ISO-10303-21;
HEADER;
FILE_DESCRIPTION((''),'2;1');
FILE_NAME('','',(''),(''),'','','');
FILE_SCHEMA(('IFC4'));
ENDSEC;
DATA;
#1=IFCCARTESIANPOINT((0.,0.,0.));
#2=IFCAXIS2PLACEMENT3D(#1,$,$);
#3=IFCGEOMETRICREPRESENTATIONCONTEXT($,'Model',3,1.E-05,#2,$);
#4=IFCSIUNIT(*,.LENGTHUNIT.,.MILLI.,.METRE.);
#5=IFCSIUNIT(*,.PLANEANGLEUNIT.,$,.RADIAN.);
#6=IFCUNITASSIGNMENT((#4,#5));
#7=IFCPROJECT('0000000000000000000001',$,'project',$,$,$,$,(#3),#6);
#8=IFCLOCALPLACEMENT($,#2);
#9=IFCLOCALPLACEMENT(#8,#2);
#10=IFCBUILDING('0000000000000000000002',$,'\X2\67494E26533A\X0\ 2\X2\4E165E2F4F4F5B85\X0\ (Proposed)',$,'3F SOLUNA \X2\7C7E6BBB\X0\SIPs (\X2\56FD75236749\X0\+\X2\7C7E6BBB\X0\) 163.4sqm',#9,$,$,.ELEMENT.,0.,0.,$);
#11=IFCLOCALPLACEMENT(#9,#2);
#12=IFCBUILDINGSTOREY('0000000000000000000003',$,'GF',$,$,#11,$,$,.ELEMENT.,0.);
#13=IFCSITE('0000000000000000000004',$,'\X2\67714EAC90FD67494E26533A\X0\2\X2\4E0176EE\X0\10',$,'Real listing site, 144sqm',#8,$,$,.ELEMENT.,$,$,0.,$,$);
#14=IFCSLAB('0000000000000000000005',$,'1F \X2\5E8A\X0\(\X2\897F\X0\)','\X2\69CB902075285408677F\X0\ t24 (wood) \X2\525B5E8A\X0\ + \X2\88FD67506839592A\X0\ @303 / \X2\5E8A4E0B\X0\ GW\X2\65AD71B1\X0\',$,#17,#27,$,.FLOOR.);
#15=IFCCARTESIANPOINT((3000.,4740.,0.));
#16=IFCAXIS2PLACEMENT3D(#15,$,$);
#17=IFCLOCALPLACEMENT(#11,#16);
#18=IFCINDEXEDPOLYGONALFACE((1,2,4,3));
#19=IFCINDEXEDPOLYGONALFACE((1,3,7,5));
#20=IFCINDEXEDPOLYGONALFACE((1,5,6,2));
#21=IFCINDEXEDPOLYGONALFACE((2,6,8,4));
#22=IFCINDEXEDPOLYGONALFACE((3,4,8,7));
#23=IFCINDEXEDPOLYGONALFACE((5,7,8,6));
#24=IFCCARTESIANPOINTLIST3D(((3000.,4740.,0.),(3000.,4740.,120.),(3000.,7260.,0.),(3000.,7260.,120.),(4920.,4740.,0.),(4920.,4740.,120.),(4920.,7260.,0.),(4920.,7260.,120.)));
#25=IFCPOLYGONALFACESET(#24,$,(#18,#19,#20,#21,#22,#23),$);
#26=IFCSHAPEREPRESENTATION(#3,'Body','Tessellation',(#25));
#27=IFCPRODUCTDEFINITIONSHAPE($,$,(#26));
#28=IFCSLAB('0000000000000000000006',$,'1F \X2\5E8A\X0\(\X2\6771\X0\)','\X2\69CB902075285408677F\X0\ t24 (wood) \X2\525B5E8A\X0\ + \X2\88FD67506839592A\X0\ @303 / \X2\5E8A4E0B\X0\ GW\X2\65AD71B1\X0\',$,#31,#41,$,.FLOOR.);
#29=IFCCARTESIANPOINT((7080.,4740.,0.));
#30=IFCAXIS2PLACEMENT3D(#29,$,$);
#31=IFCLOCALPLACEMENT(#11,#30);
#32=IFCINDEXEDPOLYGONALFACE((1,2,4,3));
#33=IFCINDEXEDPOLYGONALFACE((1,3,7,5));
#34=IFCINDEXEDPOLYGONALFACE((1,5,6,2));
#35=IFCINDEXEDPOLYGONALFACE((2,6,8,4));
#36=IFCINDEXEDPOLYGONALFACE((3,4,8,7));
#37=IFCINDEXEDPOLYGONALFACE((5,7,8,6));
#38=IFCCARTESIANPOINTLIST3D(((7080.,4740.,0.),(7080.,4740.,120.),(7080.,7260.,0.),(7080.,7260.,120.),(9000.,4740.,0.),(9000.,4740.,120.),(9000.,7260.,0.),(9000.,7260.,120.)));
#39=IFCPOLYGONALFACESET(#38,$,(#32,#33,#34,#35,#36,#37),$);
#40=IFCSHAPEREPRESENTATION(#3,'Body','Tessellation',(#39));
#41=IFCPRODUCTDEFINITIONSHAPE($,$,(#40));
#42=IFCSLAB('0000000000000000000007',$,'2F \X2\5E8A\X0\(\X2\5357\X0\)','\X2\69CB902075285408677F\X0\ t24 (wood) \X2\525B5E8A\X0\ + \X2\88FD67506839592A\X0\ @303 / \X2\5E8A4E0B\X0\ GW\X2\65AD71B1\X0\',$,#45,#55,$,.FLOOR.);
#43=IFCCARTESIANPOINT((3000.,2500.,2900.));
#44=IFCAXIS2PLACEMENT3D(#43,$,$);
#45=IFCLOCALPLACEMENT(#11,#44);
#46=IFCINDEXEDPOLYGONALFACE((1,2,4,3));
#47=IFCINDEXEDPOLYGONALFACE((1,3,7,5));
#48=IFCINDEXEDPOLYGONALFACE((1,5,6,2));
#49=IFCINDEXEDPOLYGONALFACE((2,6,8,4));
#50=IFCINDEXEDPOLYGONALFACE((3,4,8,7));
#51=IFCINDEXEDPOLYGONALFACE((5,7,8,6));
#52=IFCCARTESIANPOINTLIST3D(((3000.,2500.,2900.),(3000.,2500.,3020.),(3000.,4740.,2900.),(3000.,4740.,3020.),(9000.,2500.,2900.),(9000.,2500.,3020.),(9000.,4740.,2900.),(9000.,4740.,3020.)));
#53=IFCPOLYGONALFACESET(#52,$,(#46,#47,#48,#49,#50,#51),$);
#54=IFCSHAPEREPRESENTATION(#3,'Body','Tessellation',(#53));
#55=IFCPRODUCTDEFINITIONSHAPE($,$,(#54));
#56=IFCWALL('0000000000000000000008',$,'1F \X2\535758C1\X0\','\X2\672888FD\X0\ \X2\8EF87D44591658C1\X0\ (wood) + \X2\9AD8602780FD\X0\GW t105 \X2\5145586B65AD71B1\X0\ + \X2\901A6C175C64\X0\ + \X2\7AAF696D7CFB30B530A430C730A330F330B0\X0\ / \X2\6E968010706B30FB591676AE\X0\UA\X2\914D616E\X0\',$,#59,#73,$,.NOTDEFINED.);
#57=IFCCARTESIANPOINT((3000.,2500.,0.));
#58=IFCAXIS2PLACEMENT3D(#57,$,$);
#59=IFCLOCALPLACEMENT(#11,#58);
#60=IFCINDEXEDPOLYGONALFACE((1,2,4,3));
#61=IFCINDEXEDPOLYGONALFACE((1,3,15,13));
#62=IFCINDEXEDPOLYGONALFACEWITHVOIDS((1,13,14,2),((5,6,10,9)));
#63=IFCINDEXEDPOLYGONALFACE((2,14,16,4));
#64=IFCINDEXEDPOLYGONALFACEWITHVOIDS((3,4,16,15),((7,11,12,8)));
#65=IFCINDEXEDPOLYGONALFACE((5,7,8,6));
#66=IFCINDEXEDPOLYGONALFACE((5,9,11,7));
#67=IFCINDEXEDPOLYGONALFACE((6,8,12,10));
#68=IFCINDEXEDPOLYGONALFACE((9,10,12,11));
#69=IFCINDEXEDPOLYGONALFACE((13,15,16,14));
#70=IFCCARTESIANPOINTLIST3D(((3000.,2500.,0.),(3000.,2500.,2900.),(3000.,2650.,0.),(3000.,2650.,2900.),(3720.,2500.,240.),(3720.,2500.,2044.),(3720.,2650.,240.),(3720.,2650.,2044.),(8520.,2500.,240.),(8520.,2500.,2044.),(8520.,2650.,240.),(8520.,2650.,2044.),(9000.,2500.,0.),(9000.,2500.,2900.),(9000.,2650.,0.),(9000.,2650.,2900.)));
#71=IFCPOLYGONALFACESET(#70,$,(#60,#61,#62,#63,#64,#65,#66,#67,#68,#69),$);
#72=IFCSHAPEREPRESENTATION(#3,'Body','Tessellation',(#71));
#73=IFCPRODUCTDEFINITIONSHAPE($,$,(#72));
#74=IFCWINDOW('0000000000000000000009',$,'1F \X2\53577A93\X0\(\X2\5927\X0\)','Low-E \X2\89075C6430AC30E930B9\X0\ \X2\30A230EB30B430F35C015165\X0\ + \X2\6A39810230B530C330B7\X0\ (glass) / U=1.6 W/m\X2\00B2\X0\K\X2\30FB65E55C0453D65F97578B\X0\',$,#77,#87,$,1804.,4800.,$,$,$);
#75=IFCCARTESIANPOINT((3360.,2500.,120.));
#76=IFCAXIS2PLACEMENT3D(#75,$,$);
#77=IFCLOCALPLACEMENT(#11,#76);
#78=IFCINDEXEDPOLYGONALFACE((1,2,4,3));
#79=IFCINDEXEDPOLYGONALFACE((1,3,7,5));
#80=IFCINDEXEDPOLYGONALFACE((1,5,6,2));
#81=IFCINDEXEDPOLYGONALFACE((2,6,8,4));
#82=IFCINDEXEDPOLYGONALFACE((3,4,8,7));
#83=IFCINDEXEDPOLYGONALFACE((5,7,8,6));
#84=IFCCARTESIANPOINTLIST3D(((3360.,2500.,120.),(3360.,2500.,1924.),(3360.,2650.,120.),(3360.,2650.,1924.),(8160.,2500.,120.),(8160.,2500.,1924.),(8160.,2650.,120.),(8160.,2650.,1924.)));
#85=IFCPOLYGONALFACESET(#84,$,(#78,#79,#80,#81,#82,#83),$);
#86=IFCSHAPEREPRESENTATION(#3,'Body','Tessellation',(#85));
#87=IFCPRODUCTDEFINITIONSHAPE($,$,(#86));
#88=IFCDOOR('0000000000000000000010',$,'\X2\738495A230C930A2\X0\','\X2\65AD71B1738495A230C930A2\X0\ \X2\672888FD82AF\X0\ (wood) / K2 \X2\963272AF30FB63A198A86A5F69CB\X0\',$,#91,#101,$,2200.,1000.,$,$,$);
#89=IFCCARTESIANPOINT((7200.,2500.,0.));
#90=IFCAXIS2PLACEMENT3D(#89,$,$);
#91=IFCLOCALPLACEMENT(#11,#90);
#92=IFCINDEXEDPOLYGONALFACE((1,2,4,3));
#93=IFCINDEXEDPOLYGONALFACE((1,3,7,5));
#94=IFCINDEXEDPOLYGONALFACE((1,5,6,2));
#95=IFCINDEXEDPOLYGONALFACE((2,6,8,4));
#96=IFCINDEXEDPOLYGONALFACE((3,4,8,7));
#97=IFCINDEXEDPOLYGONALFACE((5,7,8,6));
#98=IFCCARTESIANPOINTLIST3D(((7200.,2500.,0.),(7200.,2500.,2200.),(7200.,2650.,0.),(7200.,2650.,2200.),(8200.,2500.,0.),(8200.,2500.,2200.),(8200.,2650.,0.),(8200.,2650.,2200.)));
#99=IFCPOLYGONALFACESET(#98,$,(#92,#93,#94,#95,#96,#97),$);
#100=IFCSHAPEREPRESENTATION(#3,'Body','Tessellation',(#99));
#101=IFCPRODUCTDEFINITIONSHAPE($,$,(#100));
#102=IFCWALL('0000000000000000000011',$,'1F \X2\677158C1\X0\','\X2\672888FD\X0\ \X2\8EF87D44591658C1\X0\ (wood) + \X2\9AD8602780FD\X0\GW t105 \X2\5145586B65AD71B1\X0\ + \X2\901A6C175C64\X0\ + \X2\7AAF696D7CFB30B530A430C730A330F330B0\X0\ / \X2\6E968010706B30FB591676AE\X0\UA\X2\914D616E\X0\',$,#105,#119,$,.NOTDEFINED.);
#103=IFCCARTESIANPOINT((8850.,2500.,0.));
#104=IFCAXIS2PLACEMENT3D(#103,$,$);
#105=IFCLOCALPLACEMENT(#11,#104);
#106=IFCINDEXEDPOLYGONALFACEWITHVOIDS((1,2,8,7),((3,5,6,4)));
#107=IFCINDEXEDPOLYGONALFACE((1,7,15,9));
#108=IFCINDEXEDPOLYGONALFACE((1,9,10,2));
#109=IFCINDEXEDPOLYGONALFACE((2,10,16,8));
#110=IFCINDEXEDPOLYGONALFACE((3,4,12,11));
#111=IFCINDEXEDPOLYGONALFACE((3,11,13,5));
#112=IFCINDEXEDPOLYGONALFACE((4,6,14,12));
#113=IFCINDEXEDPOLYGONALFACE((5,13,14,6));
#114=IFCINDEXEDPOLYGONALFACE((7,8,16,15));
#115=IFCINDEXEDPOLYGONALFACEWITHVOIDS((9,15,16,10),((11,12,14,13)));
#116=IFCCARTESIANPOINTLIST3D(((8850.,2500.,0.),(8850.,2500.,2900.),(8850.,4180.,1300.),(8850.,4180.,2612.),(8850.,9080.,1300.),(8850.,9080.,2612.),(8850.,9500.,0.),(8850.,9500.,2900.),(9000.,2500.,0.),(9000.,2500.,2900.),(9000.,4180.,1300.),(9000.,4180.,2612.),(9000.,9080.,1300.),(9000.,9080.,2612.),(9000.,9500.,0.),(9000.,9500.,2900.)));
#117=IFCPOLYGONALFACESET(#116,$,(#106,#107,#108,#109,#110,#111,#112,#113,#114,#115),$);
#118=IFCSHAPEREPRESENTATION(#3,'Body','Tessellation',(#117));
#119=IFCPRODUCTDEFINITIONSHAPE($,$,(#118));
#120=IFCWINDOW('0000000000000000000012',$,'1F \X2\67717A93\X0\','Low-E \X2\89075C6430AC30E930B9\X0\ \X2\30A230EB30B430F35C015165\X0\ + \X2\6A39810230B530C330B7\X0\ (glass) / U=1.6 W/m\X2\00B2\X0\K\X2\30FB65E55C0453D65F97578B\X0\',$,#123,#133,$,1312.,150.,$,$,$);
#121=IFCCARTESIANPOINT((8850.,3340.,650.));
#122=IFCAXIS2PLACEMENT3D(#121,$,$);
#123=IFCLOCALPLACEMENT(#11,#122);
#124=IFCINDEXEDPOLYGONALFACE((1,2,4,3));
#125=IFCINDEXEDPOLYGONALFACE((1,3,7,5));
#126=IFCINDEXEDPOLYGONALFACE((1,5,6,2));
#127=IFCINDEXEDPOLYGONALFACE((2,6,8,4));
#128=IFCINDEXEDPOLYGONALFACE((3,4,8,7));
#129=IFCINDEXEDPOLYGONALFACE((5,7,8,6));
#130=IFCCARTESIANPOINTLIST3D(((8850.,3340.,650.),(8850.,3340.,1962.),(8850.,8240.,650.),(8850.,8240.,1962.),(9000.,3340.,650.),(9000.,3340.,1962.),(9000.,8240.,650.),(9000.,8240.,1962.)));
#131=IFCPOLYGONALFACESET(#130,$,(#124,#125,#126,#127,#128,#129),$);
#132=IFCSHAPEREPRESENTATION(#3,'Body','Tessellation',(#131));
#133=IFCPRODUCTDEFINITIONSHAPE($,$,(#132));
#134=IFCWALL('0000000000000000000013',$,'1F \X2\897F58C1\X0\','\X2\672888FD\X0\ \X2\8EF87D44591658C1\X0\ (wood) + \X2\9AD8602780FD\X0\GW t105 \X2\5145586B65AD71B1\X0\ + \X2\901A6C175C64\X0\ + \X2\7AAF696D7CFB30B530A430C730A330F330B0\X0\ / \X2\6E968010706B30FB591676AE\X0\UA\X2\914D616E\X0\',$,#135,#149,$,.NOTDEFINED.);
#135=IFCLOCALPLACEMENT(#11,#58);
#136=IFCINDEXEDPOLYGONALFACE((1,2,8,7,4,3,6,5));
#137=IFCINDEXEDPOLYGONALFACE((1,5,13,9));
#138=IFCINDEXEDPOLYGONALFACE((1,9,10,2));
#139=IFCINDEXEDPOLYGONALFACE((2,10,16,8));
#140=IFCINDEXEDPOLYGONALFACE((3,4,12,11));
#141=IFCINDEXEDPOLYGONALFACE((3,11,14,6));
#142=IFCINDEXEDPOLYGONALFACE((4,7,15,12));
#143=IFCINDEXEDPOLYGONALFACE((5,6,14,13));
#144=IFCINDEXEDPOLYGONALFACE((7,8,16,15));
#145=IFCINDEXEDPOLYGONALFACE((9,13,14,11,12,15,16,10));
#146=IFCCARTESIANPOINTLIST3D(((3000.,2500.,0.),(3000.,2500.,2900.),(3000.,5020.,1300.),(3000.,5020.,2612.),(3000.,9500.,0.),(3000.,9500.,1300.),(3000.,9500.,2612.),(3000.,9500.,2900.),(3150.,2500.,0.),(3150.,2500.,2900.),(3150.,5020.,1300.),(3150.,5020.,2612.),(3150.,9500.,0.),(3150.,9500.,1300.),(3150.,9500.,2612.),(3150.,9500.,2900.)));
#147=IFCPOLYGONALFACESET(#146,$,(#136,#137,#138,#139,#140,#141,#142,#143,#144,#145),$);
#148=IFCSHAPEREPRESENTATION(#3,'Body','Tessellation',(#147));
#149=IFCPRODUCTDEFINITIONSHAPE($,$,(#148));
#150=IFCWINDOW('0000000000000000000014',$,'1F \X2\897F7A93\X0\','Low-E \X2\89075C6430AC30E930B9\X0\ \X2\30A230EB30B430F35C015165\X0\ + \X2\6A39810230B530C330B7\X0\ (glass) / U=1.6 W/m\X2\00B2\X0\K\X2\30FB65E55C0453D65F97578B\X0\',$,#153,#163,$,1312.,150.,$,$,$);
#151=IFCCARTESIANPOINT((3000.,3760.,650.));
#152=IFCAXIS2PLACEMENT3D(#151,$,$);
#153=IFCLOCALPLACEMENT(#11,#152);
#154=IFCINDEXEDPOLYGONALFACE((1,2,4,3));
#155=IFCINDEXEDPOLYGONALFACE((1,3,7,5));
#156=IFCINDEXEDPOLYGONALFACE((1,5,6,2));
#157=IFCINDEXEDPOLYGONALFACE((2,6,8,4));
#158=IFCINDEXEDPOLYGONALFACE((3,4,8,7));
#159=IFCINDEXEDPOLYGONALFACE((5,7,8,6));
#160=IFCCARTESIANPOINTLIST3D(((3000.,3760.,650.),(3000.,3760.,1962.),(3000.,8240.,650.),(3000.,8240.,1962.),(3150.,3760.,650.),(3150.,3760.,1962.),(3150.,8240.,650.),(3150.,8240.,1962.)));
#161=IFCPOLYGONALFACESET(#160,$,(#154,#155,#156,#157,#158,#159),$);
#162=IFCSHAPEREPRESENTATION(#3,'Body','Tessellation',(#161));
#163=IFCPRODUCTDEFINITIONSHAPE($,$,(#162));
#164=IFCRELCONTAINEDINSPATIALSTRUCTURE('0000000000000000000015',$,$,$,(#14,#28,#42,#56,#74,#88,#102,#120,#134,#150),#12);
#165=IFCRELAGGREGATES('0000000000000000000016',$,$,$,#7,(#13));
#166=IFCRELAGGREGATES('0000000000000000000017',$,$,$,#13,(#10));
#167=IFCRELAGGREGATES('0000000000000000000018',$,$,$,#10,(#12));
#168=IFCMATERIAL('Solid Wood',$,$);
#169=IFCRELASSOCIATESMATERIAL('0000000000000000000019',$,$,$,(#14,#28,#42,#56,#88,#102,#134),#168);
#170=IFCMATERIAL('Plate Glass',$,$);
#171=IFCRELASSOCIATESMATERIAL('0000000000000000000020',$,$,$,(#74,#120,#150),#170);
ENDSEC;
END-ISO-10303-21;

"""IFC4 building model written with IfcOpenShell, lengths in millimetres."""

from ifc_helpers import new_model, si_unit, frame, frame_2d, origin, place, context, project, spatial, rectangle, extrude, material, element, fill, save


model = new_model("IFC4")

# Units and contexts
model_context = context("Model", 3, precision=1e-05, world=origin())
ifc_project = project(units=[si_unit("LENGTHUNIT", "METRE", prefix="MILLI"), si_unit("PLANEANGLEUNIT", "RADIAN")], contexts=[model_context])

# Site, building, storey
site_placement = place(None, origin())
site = spatial("IfcSite", under=ifc_project, at=site_placement, Name="東京都杉並区2丁目10", ObjectType="Real listing site, 144sqm", CompositionType="ELEMENT", RefElevation=0.0)
building_placement = place(site_placement, origin())
building = spatial("IfcBuilding", under=site, at=building_placement, Name="杉並区 2世帯住宅 (Proposed)", ObjectType="3F SOLUNA 籾殻SIPs (国産杉+籾殻) 163.4sqm", CompositionType="ELEMENT", ElevationOfRefHeight=0.0, ElevationOfTerrain=0.0)
storey_placement = place(building_placement, origin())
storey = spatial("IfcBuildingStorey", under=building, at=storey_placement, Name="GF", CompositionType="ELEMENT", Elevation=0.0)

# Slabs
ifc_material_1 = material(Name="Solid Wood")
slab_1_placement = place(storey_placement, frame((3000.0, 4740.0, 0.0)))
element("IfcSlab", 1, at=slab_1_placement, inside=storey, material=ifc_material_1, Name="1F 床(西)", Description="構造用合板 t24 (wood) 剛床 + 製材根太 @303 / 床下 GW断熱", PredefinedType="FLOOR", context=model_context, shape_type="SweptSolid", body=[
    extrude(rectangle(XDim=1920.0, YDim=2520.0, at=frame_2d((960.0, 1260.0))), frame((3000.0, 4740.0, 0.0)), (0.0, 0.0, 1.0), 120.0),
])
slab_2_placement = place(storey_placement, frame((7080.0, 4740.0, 0.0)))
element("IfcSlab", 2, at=slab_2_placement, inside=storey, material=ifc_material_1, Name="1F 床(東)", Description="構造用合板 t24 (wood) 剛床 + 製材根太 @303 / 床下 GW断熱", PredefinedType="FLOOR", context=model_context, shape_type="SweptSolid", body=[
    extrude(rectangle(XDim=1920.0, YDim=2520.0, at=frame_2d((960.0, 1260.0))), frame((7080.0, 4740.0, 0.0)), (0.0, 0.0, 1.0), 120.0),
])
slab_3_placement = place(storey_placement, frame((3000.0, 2500.0, 2900.0)))
element("IfcSlab", 3, at=slab_3_placement, inside=storey, material=ifc_material_1, Name="2F 床(南)", Description="構造用合板 t24 (wood) 剛床 + 製材根太 @303 / 床下 GW断熱", PredefinedType="FLOOR", context=model_context, shape_type="SweptSolid", body=[
    extrude(rectangle(XDim=6000.0, YDim=2240.0, at=frame_2d((3000.0, 1120.0))), frame((3000.0, 2500.0, 2900.0)), (0.0, 0.0, 1.0), 120.0),
])

# Wall, openings, window, door
wall_1_placement = place(storey_placement, frame((3000.0, 2500.0, 0.0)))
wall_1 = element("IfcWall", 4, at=wall_1_placement, inside=storey, material=ifc_material_1, Name="1F 南壁", Description="木製 軸組外壁 (wood) + 高性能GW t105 充填断熱 + 通気層 + 窯業系サイディング / 準耐火・外皮UA配慮", PredefinedType="NOTDEFINED", context=model_context, shape_type="SweptSolid", body=[
    extrude(rectangle(XDim=6000.0, YDim=150.0, at=frame_2d((3000.0, 75.0))), frame((3000.0, 2500.0, 0.0)), (0.0, 0.0, 1.0), 2900.0),
])
opening_1_placement = place(storey_placement, frame((3360.0, 2500.0, 120.0)))
opening_1 = element("IfcOpeningElement", 5, at=opening_1_placement, cuts=wall_1, PredefinedType="NOTDEFINED", context=model_context, shape_type="SweptSolid", body=[
    extrude(rectangle(XDim=4800.0, YDim=150.0, at=frame_2d((2400.0, 75.0))), frame((3360.0, 2500.0, 120.0)), (0.0, 0.0, 1.0), 1804.0),
])
opening_2_placement = place(storey_placement, frame((7200.0, 2500.0, 0.0)))
opening_2 = element("IfcOpeningElement", 6, at=opening_2_placement, cuts=wall_1, PredefinedType="NOTDEFINED", context=model_context, shape_type="SweptSolid", body=[
    extrude(rectangle(XDim=1000.0, YDim=150.0, at=frame_2d((500.0, 75.0))), frame((7200.0, 2500.0, 0.0)), (0.0, 0.0, 1.0), 2200.0),
])
ifc_material_2 = material(Name="Plate Glass")
window_1_placement = place(storey_placement, frame((3360.0, 2500.0, 120.0)))
window_1 = element("IfcWindow", 7, at=window_1_placement, inside=storey, material=ifc_material_2, Name="1F 南窓(大)", Description="Low-E 複層ガラス アルゴン封入 + 樹脂サッシ (glass) / U=1.6 W/m²K・日射取得型", OverallHeight=1804.0, OverallWidth=4800.0, context=model_context, shape_type="SweptSolid", body=[
    extrude(rectangle(XDim=4800.0, YDim=150.0, at=frame_2d((2400.0, 75.0))), frame((3360.0, 2500.0, 120.0)), (0.0, 0.0, 1.0), 1804.0),
])
fill(opening_1, window_1)
door_placement = place(storey_placement, frame((7200.0, 2500.0, 0.0)))
door = element("IfcDoor", 8, at=door_placement, inside=storey, material=ifc_material_1, Name="玄関ドア", Description="断熱玄関ドア 木製芯 (wood) / K2 防犯・採風機構", OverallHeight=2200.0, OverallWidth=1000.0, context=model_context, shape_type="SweptSolid", body=[
    extrude(rectangle(XDim=1000.0, YDim=150.0, at=frame_2d((500.0, 75.0))), frame((7200.0, 2500.0, 0.0)), (0.0, 0.0, 1.0), 2200.0),
])
fill(opening_2, door)

# Walls, openings, windows
wall_2_placement = place(storey_placement, frame((8850.0, 2500.0, 0.0)))
wall_2 = element("IfcWall", 9, at=wall_2_placement, inside=storey, material=ifc_material_1, Name="1F 東壁", Description="木製 軸組外壁 (wood) + 高性能GW t105 充填断熱 + 通気層 + 窯業系サイディング / 準耐火・外皮UA配慮", PredefinedType="NOTDEFINED", context=model_context, shape_type="SweptSolid", body=[
    extrude(rectangle(XDim=150.0, YDim=7000.0, at=frame_2d((75.0, 3500.0))), frame((8850.0, 2500.0, 0.0)), (0.0, 0.0, 1.0), 2900.0),
])
opening_3_placement = place(storey_placement, frame((8850.0, 3340.0, 650.0)))
opening_3 = element("IfcOpeningElement", 10, at=opening_3_placement, cuts=wall_2, PredefinedType="NOTDEFINED", context=model_context, shape_type="SweptSolid", body=[
    extrude(rectangle(XDim=150.0, YDim=4900.0, at=frame_2d((75.0, 2450.0))), frame((8850.0, 3340.0, 650.0)), (0.0, 0.0, 1.0), 1312.0),
])
window_2_placement = place(storey_placement, frame((8850.0, 3340.0, 650.0)))
window_2 = element("IfcWindow", 11, at=window_2_placement, inside=storey, material=ifc_material_2, Name="1F 東窓", Description="Low-E 複層ガラス アルゴン封入 + 樹脂サッシ (glass) / U=1.6 W/m²K・日射取得型", OverallHeight=1312.0, OverallWidth=150.0, context=model_context, shape_type="SweptSolid", body=[
    extrude(rectangle(XDim=150.0, YDim=4900.0, at=frame_2d((75.0, 2450.0))), frame((8850.0, 3340.0, 650.0)), (0.0, 0.0, 1.0), 1312.0),
])
fill(opening_3, window_2)
wall_3_placement = place(storey_placement, frame((3000.0, 2500.0, 0.0)))
wall_3 = element("IfcWall", 12, at=wall_3_placement, inside=storey, material=ifc_material_1, Name="1F 西壁", Description="木製 軸組外壁 (wood) + 高性能GW t105 充填断熱 + 通気層 + 窯業系サイディング / 準耐火・外皮UA配慮", PredefinedType="NOTDEFINED", context=model_context, shape_type="SweptSolid", body=[
    extrude(rectangle(XDim=150.0, YDim=7000.0, at=frame_2d((75.0, 3500.0))), frame((3000.0, 2500.0, 0.0)), (0.0, 0.0, 1.0), 2900.0),
])
opening_4_placement = place(storey_placement, frame((3000.0, 3760.0, 650.0)))
opening_4 = element("IfcOpeningElement", 13, at=opening_4_placement, cuts=wall_3, PredefinedType="NOTDEFINED", context=model_context, shape_type="SweptSolid", body=[
    extrude(rectangle(XDim=150.0, YDim=4480.0, at=frame_2d((75.0, 2240.0))), frame((3000.0, 3760.0, 650.0)), (0.0, 0.0, 1.0), 1312.0),
])
window_3_placement = place(storey_placement, frame((3000.0, 3760.0, 650.0)))
window_3 = element("IfcWindow", 14, at=window_3_placement, inside=storey, material=ifc_material_2, Name="1F 西窓", Description="Low-E 複層ガラス アルゴン封入 + 樹脂サッシ (glass) / U=1.6 W/m²K・日射取得型", OverallHeight=1312.0, OverallWidth=150.0, context=model_context, shape_type="SweptSolid", body=[
    extrude(rectangle(XDim=150.0, YDim=4480.0, at=frame_2d((75.0, 2240.0))), frame((3000.0, 3760.0, 650.0)), (0.0, 0.0, 1.0), 1312.0),
])
fill(opening_4, window_3)

save(model, "model.ifc")
